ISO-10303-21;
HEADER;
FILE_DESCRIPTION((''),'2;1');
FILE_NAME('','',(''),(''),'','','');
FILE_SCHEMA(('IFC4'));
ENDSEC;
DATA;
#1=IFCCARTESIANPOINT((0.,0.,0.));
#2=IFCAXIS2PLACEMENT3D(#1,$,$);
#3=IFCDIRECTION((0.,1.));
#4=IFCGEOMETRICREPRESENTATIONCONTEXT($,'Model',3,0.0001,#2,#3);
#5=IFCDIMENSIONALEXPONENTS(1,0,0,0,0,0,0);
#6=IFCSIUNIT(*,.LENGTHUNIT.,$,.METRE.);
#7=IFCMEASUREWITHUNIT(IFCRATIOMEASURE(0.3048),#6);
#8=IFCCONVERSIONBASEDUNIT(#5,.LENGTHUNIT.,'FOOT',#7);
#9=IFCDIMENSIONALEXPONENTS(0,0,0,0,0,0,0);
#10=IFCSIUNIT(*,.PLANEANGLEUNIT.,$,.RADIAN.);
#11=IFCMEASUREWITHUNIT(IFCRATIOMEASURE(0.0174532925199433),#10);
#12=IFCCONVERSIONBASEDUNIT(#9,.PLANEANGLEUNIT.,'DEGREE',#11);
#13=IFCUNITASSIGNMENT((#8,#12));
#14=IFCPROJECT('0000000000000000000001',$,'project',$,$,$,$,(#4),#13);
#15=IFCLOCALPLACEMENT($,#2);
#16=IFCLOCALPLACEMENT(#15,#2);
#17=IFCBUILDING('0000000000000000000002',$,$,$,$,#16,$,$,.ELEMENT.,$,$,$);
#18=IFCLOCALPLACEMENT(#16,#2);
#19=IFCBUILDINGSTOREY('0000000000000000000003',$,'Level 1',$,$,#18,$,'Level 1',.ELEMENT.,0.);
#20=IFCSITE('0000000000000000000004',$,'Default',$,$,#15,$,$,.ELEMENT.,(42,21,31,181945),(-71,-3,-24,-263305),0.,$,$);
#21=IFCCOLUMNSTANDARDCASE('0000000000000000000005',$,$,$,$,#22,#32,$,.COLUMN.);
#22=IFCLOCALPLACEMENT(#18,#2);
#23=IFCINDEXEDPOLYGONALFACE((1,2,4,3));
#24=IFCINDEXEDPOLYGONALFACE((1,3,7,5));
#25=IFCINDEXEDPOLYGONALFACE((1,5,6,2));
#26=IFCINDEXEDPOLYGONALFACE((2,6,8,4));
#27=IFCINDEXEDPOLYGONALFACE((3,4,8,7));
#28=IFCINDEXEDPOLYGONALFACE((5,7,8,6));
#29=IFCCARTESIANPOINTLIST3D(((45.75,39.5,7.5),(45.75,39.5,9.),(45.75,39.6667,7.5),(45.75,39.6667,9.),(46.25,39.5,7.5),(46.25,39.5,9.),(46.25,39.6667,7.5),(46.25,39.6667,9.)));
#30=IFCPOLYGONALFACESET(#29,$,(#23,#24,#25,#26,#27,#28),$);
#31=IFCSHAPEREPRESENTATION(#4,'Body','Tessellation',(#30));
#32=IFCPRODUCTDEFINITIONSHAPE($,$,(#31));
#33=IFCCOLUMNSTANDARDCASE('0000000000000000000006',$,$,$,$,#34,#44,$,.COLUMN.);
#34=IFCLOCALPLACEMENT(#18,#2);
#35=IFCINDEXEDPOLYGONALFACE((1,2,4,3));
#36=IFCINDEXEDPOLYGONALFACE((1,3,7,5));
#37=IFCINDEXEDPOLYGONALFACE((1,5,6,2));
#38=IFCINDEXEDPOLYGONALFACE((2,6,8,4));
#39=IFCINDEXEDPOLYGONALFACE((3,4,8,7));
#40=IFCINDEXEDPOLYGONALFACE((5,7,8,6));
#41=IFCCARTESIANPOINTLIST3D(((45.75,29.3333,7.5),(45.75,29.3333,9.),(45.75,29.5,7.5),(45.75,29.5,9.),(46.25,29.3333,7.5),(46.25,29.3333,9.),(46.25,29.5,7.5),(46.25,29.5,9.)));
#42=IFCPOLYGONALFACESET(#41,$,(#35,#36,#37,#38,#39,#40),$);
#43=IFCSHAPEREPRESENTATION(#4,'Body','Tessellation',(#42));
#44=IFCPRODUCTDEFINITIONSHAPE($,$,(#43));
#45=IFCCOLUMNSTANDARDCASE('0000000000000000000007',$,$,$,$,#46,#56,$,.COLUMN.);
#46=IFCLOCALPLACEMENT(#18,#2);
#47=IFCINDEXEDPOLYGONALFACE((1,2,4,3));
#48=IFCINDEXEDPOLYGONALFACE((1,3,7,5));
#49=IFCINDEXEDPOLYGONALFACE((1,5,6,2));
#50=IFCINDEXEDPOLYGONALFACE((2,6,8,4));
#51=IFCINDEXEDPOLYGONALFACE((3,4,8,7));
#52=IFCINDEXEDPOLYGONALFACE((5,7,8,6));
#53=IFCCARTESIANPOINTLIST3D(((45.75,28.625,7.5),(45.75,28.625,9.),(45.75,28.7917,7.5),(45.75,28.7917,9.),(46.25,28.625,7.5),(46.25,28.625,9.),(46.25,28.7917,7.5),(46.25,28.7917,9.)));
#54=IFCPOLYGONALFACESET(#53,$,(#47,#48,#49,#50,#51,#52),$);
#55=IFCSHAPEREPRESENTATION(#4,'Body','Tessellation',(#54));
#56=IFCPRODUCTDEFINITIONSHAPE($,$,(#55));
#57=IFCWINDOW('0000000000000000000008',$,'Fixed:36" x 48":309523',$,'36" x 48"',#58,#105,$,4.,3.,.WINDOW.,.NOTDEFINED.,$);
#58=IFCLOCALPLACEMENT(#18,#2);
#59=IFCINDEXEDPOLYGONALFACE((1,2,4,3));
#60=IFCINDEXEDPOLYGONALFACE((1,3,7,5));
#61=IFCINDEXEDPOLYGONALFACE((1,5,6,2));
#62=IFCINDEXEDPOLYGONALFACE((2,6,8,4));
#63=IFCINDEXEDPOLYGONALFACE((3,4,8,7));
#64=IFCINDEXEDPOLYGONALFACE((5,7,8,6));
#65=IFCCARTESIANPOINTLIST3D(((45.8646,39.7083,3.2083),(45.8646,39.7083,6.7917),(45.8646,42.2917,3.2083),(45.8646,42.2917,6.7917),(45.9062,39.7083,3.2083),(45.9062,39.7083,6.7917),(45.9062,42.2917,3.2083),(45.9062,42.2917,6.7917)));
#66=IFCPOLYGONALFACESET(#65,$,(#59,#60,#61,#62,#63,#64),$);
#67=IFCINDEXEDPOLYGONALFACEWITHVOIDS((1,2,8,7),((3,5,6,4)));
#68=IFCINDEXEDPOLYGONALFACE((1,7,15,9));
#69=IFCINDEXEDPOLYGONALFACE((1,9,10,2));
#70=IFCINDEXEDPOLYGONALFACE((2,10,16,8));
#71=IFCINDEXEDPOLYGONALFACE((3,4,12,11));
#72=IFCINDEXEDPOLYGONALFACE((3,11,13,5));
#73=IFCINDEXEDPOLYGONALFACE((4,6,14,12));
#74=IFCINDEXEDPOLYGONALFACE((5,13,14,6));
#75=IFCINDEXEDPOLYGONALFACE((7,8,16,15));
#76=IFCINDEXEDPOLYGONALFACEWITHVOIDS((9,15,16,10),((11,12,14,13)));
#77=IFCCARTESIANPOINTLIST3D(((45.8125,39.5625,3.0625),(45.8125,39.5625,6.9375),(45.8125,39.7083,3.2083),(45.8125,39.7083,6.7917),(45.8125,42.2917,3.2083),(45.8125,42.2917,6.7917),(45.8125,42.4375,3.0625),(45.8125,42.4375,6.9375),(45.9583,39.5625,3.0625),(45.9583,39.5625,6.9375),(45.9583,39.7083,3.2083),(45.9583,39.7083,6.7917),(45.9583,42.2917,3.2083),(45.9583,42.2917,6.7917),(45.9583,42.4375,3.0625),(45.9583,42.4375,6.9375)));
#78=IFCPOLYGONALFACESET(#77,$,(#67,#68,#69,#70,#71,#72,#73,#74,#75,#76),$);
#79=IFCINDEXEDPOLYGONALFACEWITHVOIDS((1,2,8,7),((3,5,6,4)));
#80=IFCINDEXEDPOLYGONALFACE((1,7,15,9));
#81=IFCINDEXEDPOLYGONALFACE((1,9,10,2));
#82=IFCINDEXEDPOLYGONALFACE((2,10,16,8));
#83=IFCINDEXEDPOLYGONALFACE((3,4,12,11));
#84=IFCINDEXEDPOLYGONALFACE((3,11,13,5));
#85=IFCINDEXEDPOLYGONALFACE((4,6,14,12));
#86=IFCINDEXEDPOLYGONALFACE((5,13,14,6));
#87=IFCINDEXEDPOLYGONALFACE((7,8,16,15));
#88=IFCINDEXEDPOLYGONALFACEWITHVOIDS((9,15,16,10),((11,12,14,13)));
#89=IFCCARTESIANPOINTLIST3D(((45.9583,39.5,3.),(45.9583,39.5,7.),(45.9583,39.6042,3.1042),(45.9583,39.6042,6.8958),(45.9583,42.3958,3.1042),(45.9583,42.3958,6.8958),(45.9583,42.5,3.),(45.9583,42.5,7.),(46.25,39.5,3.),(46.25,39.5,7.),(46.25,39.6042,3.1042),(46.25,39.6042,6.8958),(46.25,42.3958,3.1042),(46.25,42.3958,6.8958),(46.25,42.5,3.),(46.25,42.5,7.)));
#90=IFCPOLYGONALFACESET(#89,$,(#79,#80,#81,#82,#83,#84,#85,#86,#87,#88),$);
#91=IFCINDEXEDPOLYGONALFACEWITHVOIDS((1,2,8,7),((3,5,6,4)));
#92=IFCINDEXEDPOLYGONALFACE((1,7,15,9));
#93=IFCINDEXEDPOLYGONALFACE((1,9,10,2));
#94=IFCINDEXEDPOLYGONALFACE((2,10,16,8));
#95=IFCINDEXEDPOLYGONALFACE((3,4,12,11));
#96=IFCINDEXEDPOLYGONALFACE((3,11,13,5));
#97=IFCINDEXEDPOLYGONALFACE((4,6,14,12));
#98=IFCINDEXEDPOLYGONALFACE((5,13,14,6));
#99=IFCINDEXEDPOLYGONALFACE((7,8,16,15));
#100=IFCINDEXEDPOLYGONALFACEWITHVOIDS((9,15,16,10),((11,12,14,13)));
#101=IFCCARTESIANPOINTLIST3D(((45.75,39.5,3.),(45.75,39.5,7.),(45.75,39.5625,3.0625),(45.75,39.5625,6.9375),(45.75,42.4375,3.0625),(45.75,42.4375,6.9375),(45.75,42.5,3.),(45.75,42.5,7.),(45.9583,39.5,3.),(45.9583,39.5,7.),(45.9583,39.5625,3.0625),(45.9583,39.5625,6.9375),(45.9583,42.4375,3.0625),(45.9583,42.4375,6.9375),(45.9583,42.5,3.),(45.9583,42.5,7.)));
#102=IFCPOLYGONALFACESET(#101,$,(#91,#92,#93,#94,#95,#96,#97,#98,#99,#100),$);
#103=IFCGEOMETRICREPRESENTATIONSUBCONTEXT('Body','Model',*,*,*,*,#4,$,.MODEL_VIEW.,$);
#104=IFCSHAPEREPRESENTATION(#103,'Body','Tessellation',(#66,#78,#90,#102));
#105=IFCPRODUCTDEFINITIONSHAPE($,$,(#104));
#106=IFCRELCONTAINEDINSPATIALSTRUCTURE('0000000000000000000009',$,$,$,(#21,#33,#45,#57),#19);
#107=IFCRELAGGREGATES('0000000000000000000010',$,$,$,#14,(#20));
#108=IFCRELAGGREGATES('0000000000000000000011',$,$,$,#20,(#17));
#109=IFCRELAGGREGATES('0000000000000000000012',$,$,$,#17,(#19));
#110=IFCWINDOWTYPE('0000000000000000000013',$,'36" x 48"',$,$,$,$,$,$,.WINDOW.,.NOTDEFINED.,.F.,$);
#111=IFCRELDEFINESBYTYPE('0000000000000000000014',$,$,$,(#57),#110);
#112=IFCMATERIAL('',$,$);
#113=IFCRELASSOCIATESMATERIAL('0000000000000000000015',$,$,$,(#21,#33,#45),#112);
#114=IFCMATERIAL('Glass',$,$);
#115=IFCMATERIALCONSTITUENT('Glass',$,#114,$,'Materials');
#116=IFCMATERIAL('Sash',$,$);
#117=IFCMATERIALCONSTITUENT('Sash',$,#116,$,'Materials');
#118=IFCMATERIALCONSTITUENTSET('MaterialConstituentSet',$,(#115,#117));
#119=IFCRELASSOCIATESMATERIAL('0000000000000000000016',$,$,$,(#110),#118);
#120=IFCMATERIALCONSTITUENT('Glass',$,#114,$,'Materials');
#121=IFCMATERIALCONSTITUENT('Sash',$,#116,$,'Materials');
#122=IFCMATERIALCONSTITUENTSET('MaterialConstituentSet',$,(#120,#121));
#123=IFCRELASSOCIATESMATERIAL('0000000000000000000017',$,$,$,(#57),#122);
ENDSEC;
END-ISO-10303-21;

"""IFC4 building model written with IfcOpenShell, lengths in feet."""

from ifc_helpers import new_model, entity, si_unit, converted_unit, direction, frame, frame_2d, origin, place, context, subcontext, project, spatial, polyline, rectangle, outline, extrude, source, transform, mapped, material, constituent, constituent_set, type_object, type_shapes, element, save


model = new_model("IFC4")

# Units and contexts
model_context = context("Model", 3, precision=0.0001, world=origin(), true_north=direction((0.0, 1.0)))
body_context = subcontext(model_context, "Body", "Model", "MODEL_VIEW")
ifc_project = project(units=[converted_unit("LENGTHUNIT", "FOOT", entity("IfcRatioMeasure", 0.3048), si_unit("LENGTHUNIT", "METRE"), dimensions=[1, 0, 0, 0, 0, 0, 0]), converted_unit("PLANEANGLEUNIT", "DEGREE", entity("IfcRatioMeasure", 0.0174532925199433), si_unit("PLANEANGLEUNIT", "RADIAN"), dimensions=[0, 0, 0, 0, 0, 0, 0])], contexts=[model_context])

# Site, building, storey
site_placement = place(None, origin())
site = spatial("IfcSite", under=ifc_project, at=site_placement, Name="Default", CompositionType="ELEMENT", RefLatitude=(42, 21, 31, 181945), RefLongitude=(-71, -3, -24, -263305), RefElevation=0.0)
building_placement = place(site_placement, origin())
building = spatial("IfcBuilding", under=site, at=building_placement, CompositionType="ELEMENT")
storey_placement = place(building_placement, origin())
storey = spatial("IfcBuildingStorey", under=building, at=storey_placement, Name="Level 1", LongName="Level 1", CompositionType="ELEMENT", Elevation=0.0)

# Columns
placement_1 = place(storey_placement, frame((46.0, 46.25, 0.0), z_axis=(0.0, 0.0, 1.0), x_axis=(0.0, -1.0, 0.0)))
ifc_material_1 = material(Name="")
for number, where, z_axis, x_axis in (
    (1, (6.6667, 0.0, 7.5), (0.0, 0.0, 1.0), (1.0, 0.0, 0.0)),
    (2, (16.8334, 0.0, 7.5), (0.0, 0.0, 1.0), (1.0, 0.0, 0.0)),
    (3, (17.5417, 0.0, 7.5), (0.0, 0.0, 1.0), (1.0, 0.0, 0.0)),
):
    element("IfcColumnStandardCase", number, at=place(placement_1, frame(where, z_axis=z_axis, x_axis=x_axis)), inside=storey, material=ifc_material_1, PredefinedType="COLUMN", context=model_context, shape_type="SweptSolid", body=[
        extrude(rectangle(XDim=0.1667, YDim=0.5), origin(), (0.0, 0.0, 1.0), 1.5),
    ])

# Window
ifc_material_2 = material(Name="Glass")
ifc_constituent_1 = constituent(ifc_material_2, Name="Glass", Category="Materials")
ifc_material_3 = material(Name="Sash")
ifc_constituent_2 = constituent(ifc_material_3, Name="Sash", Category="Materials")
ifc_constituent_set_1 = constituent_set(constituents=[ifc_constituent_1, ifc_constituent_2], Name="MaterialConstituentSet")
ifc_constituent_3 = constituent(ifc_material_2, Name="Glass", Category="Materials")
ifc_constituent_4 = constituent(ifc_material_3, Name="Sash", Category="Materials")
ifc_constituent_set_2 = constituent_set(constituents=[ifc_constituent_3, ifc_constituent_4], Name="MaterialConstituentSet")
window_type = type_object("IfcWindowType", Name="36\" x 48\"", ParameterTakesPrecedence=False, PartitioningType="NOTDEFINED", PredefinedType="WINDOW", material=ifc_constituent_set_2)
shared_shape = source(origin(), body_context, "Body", "SweptSolid", [
    extrude(rectangle(XDim=0.0417, YDim=2.5833, at=frame_2d((0.0, 0.0), x_axis=(1.0, 0.0))), frame((1.5, 0.3646, 0.2083), z_axis=(0.0, 0.0, 1.0), x_axis=(0.0, 1.0, 0.0)), (0.0, 0.0, 1.0), 3.5833),
    extrude(outline(polyline([(-1.4375, -1.9375), (1.4375, -1.9375), (1.4375, 1.9375), (-1.4375, 1.9375), (-1.4375, -1.9375)]), holes=[polyline([(-1.2917, -1.7917), (-1.2917, 1.7917), (1.2917, 1.7917), (1.2917, -1.7917), (-1.2917, -1.7917)])]), frame((1.5, 0.2917, 2.0), z_axis=(0.0, 1.0, 0.0), x_axis=(1.0, 0.0, 0.0)), (0.0, 0.0, 1.0), 0.1458),
    extrude(outline(polyline([(-1.5, -2.0), (1.5, -2.0), (1.5, 2.0), (-1.5, 2.0), (-1.5, -2.0)]), holes=[polyline([(-1.3958, -1.8958), (-1.3958, 1.8958), (1.3958, 1.8958), (1.3958, -1.8958), (-1.3958, -1.8958)])]), frame((1.5, 0.0, 2.0), z_axis=(0.0, 1.0, 0.0), x_axis=(1.0, 0.0, 0.0)), (0.0, 0.0, 1.0), 0.2917),
    extrude(outline(polyline([(-2.0, -1.5), (2.0, -1.5), (2.0, 1.5), (-2.0, 1.5), (-2.0, -1.5)]), holes=[polyline([(-1.9375, -1.4375), (-1.9375, 1.4375), (1.9375, 1.4375), (1.9375, -1.4375), (-1.9375, -1.4375)])]), frame((1.5, 0.2917, 2.0), z_axis=(0.0, 1.0, 0.0), x_axis=(0.0, 0.0, -1.0)), (0.0, 0.0, 1.0), 0.2083),
])
type_shapes(window_type, [shared_shape])
placement_2 = place(placement_1, frame((6.75, 0.25, 3.0)))
window_placement = place(placement_2, frame((0.0, 0.0, 0.0), z_axis=(0.0, 0.0, 1.0), x_axis=(-1.0, 0.0, 0.0)))
element("IfcWindow", 4, at=window_placement, inside=storey, type_object=window_type, material=ifc_constituent_set_1, Name="Fixed:36\" x 48\":309523", ObjectType="36\" x 48\"", OverallHeight=4.0, OverallWidth=3.0, PartitioningType="NOTDEFINED", PredefinedType="WINDOW", context=body_context, shape_type="MappedRepresentation", body=[
    mapped(shared_shape, transform((0.0, 0.0, 0.0), scale=1.0)),
])

save(model, "model.ifc")
